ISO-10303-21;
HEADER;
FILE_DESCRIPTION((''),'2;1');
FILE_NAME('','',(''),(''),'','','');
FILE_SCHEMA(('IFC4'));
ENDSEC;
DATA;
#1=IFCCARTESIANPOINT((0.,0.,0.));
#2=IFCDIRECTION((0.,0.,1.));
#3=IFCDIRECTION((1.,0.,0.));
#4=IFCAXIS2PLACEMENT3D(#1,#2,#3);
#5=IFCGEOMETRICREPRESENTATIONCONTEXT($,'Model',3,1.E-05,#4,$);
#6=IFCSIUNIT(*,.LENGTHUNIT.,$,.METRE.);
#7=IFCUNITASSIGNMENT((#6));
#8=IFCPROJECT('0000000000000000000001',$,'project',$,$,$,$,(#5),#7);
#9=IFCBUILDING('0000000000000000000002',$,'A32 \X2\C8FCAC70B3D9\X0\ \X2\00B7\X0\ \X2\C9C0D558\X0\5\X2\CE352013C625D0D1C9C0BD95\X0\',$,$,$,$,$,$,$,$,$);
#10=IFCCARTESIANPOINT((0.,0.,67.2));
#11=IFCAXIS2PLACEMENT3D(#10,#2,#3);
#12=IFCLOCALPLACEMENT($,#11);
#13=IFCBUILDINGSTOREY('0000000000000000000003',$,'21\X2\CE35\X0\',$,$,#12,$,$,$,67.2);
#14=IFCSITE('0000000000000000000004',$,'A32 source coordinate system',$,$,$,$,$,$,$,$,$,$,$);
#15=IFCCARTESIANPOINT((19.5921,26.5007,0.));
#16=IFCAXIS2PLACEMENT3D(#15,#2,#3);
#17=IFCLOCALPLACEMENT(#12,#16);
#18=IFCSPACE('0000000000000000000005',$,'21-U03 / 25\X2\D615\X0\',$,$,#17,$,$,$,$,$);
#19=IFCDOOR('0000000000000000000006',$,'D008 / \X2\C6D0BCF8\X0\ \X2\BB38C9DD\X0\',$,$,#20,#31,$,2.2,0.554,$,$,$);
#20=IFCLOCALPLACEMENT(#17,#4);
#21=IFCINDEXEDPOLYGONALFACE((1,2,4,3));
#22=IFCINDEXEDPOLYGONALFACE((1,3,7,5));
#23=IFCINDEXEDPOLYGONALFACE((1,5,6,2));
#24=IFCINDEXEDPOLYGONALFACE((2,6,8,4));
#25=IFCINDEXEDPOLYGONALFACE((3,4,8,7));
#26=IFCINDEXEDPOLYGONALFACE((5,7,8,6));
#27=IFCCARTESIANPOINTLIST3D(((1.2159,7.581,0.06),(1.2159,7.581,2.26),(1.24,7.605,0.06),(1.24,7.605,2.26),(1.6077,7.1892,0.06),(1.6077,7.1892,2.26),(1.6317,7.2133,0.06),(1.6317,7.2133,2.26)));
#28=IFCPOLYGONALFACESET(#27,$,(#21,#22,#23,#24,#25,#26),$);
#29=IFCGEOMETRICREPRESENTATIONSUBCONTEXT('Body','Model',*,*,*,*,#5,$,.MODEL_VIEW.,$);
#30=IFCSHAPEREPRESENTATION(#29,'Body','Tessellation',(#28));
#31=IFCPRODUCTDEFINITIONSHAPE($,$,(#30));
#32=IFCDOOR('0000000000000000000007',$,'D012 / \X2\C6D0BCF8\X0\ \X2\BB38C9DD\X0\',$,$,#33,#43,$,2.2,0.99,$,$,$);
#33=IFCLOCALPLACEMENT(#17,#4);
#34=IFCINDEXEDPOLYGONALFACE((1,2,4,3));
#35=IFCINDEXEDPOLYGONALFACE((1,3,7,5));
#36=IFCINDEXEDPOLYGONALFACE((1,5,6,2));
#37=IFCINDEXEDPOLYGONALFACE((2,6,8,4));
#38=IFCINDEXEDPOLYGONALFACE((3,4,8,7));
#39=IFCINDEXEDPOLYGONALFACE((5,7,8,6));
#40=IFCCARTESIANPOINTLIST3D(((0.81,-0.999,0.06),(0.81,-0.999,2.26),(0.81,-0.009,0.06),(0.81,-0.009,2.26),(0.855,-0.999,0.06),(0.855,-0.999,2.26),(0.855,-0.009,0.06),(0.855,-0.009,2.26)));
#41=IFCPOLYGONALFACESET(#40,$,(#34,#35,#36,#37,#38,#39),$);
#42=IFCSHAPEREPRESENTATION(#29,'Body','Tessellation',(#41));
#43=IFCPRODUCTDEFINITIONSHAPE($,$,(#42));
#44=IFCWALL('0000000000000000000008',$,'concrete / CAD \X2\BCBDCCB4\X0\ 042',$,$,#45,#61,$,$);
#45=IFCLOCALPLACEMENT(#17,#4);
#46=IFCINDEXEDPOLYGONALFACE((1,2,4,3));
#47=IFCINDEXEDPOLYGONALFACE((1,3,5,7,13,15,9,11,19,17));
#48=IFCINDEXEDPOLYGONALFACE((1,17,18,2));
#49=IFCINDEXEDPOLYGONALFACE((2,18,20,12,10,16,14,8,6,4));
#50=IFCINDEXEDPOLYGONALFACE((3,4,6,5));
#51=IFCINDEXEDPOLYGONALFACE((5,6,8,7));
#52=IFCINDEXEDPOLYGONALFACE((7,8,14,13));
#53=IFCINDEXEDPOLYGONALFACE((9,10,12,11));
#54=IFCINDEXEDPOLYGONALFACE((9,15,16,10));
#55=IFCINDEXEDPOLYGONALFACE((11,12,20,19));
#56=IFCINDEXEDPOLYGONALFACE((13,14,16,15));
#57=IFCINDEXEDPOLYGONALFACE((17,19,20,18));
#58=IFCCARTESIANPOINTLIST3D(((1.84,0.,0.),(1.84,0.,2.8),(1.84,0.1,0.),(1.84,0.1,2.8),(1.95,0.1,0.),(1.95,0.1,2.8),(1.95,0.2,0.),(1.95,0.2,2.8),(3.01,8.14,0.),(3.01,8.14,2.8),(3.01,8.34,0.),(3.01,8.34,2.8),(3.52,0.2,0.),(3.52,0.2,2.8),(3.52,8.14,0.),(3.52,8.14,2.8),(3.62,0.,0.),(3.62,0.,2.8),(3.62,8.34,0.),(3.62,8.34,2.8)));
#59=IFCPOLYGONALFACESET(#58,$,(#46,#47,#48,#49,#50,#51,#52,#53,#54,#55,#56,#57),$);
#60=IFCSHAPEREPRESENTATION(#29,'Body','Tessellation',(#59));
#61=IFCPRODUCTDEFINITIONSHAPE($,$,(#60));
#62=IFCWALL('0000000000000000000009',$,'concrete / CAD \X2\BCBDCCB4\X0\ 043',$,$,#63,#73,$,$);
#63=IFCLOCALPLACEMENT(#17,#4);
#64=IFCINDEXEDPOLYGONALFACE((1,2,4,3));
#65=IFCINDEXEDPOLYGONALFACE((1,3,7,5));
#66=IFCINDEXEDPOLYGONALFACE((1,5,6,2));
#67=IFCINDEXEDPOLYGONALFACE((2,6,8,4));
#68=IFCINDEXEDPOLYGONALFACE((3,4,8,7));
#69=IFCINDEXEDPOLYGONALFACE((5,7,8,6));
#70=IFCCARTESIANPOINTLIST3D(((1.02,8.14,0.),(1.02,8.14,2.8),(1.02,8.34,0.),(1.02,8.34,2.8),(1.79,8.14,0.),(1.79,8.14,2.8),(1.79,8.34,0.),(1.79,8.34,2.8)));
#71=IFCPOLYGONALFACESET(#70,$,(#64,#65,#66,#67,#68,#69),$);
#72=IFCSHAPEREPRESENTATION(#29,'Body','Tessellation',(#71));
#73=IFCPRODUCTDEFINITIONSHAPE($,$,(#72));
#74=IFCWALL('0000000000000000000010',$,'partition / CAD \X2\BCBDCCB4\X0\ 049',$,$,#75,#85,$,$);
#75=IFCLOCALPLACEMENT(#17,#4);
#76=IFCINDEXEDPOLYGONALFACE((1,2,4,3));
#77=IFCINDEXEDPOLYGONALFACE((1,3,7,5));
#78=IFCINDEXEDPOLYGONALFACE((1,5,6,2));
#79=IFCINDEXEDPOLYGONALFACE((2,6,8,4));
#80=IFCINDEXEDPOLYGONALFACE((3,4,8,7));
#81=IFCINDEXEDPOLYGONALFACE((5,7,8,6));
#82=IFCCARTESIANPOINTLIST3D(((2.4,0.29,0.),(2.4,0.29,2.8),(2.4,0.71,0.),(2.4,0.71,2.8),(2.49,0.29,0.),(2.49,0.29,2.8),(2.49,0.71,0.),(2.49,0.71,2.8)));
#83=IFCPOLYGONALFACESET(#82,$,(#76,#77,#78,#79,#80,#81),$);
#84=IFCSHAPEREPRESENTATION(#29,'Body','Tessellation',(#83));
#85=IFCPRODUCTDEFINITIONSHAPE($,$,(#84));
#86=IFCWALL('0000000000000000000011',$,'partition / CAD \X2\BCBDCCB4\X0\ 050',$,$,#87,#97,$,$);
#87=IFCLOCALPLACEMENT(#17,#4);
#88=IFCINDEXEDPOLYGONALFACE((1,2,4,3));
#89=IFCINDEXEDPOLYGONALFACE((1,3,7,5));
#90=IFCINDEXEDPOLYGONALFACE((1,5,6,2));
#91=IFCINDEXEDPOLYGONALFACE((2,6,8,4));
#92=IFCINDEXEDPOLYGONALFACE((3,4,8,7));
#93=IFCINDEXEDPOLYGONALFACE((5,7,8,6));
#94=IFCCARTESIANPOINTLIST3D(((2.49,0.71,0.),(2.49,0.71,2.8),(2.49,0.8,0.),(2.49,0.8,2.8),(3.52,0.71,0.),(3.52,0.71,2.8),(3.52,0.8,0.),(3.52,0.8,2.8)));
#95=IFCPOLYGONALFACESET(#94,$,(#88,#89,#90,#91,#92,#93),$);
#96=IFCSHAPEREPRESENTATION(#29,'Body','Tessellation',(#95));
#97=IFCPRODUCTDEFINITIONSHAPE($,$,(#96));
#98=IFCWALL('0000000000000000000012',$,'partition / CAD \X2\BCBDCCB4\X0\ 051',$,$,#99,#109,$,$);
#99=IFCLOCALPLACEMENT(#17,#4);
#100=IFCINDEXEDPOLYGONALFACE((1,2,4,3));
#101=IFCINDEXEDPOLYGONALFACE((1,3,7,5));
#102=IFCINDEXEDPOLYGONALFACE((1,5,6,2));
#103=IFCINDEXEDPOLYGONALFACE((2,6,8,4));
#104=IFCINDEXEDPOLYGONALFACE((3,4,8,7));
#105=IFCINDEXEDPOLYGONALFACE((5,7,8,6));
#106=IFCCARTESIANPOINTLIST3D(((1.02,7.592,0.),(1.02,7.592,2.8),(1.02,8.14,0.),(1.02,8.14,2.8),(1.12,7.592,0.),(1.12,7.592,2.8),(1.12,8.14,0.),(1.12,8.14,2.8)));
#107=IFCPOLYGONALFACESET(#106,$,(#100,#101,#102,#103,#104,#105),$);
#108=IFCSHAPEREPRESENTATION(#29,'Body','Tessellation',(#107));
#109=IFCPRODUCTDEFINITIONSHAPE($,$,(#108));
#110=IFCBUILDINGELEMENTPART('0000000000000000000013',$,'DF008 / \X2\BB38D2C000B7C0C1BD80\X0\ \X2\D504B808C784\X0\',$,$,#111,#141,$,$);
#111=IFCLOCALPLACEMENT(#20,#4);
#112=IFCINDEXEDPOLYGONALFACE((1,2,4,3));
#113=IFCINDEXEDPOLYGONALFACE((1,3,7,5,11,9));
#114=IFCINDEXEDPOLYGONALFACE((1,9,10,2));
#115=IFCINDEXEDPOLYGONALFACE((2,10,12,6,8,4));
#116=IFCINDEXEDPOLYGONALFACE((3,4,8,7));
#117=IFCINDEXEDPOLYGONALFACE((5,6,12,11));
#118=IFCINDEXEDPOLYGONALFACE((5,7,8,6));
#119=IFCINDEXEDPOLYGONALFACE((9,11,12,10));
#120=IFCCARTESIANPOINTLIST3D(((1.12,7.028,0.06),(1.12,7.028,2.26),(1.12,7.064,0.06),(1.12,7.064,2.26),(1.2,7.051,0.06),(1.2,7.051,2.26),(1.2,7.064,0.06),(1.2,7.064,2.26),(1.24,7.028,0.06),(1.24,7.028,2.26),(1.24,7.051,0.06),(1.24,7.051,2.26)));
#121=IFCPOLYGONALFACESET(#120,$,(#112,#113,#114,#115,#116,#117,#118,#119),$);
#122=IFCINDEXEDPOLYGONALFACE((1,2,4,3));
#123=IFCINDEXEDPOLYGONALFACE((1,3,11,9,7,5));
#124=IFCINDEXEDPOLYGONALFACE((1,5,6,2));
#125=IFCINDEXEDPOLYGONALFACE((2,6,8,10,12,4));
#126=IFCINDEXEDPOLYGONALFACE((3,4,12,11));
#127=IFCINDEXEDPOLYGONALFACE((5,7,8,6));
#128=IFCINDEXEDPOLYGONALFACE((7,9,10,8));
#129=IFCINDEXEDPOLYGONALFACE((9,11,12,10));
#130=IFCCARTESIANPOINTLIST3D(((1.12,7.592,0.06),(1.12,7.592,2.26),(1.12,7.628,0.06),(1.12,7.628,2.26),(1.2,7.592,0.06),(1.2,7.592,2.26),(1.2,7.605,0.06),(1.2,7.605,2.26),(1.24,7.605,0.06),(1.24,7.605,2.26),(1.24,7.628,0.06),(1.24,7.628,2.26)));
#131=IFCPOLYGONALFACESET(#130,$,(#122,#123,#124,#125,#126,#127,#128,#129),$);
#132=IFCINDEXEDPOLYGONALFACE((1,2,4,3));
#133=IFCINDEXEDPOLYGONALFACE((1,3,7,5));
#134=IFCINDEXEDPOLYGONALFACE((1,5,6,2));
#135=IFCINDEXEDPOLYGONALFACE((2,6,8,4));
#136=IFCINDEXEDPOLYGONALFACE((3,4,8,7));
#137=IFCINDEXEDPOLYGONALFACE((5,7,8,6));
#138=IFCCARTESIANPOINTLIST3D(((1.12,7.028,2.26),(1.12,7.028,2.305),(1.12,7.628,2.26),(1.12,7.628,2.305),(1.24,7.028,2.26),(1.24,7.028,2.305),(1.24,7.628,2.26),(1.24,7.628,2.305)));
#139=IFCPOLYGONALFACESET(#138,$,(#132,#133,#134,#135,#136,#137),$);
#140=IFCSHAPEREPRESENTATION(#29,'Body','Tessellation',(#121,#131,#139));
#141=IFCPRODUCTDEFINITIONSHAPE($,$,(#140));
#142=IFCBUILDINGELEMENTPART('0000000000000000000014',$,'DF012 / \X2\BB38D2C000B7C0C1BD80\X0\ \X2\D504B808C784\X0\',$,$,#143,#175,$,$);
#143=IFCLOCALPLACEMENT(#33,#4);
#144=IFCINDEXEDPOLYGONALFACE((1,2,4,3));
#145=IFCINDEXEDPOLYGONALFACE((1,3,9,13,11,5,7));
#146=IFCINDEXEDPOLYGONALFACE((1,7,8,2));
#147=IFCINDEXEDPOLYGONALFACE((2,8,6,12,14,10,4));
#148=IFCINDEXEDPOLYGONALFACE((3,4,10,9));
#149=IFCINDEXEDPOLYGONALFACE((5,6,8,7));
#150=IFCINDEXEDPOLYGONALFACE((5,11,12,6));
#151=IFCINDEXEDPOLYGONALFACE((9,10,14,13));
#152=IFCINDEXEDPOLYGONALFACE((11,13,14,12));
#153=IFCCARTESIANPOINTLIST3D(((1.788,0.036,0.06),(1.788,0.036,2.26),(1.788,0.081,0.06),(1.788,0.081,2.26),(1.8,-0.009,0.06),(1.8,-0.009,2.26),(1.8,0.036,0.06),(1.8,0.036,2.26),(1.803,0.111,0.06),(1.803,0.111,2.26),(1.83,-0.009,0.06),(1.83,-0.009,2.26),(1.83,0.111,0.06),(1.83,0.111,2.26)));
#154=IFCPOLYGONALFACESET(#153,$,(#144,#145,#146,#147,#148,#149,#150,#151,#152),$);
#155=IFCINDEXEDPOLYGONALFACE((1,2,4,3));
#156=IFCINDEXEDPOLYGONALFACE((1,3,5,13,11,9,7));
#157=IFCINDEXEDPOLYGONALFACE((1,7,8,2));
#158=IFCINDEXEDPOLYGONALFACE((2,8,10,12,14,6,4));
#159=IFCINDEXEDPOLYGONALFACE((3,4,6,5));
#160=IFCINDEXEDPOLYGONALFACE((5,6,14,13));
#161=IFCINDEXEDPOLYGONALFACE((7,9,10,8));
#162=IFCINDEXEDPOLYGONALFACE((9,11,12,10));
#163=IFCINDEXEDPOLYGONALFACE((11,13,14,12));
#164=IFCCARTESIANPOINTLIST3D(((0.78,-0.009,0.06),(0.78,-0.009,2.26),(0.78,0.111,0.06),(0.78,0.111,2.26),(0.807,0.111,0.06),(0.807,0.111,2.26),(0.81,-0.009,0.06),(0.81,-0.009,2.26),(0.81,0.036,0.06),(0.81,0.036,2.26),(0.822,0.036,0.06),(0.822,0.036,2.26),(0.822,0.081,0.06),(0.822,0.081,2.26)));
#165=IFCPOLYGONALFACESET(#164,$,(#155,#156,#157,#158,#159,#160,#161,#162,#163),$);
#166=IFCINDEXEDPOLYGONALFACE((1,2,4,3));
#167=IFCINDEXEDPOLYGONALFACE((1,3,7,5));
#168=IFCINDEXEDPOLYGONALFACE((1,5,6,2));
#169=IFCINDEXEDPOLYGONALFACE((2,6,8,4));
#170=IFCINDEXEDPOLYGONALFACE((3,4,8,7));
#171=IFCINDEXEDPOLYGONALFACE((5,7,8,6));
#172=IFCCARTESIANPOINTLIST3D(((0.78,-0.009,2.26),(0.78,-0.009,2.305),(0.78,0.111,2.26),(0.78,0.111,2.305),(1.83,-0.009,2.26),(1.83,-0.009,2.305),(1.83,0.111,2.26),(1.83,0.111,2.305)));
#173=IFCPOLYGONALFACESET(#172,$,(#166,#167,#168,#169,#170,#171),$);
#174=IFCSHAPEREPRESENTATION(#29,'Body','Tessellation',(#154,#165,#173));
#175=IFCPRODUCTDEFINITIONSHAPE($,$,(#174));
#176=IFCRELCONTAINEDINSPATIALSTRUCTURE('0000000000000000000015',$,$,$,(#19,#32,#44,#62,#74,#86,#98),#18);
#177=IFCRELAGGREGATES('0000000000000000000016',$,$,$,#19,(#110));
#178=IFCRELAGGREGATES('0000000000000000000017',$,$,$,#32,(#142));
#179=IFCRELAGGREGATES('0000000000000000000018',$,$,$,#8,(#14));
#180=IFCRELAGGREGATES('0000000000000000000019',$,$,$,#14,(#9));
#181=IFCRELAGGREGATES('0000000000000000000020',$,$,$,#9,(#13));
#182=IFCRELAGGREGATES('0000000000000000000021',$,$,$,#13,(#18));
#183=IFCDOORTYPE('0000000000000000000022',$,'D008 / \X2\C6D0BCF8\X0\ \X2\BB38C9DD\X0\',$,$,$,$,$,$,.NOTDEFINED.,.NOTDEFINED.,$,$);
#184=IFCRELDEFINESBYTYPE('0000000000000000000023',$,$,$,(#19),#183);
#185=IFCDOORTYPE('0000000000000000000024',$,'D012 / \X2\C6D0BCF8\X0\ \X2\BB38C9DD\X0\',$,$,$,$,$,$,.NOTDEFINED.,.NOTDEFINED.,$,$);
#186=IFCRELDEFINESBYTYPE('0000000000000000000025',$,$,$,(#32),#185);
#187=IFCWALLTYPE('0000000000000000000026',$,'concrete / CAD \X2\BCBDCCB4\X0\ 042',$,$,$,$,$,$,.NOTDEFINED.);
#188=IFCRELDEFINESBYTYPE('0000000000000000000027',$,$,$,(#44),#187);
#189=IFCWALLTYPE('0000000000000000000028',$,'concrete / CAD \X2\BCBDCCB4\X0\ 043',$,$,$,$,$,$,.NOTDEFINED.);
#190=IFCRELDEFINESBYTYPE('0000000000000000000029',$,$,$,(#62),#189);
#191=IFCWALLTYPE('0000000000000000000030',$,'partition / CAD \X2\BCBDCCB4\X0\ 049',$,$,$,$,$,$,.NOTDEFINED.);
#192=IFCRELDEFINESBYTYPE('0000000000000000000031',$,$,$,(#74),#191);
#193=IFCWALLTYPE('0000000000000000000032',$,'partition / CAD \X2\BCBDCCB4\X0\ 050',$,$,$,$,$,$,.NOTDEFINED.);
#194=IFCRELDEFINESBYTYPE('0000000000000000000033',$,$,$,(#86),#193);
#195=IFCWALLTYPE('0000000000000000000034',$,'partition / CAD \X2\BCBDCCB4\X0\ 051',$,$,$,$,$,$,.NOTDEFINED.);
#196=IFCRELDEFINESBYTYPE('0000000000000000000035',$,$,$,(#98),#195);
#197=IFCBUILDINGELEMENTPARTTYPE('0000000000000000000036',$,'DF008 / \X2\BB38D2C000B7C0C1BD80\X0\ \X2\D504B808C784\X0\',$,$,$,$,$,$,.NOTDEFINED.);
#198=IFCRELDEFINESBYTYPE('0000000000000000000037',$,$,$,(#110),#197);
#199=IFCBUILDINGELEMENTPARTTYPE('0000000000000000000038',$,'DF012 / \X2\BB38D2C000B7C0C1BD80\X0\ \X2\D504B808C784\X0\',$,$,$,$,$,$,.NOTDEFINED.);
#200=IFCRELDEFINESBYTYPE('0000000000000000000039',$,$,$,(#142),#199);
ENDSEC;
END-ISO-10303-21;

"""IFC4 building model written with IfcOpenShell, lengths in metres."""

from ifc_helpers import new_model, si_unit, frame, origin, origin_with_axes, place, context, subcontext, project, spatial, polyline, outline, extrude, source, transform, mapped, type_object, type_shapes, element, aggregate, save


model = new_model("IFC4")

# Units and contexts
model_context = context("Model", 3, precision=1e-05, world=origin_with_axes())
body_context = subcontext(model_context, "Body", "Model", "MODEL_VIEW")
ifc_project = project(units=[si_unit("LENGTHUNIT", "METRE")], contexts=[model_context])

# Site, building, storey, space
storey_placement = place(None, frame((0.0, 0.0, 67.2), z_axis=(0.0, 0.0, 1.0), x_axis=(1.0, 0.0, 0.0)))
space_placement = place(storey_placement, frame((19.5921, 26.5007, 0.0), z_axis=(0.0, 0.0, 1.0), x_axis=(1.0, 0.0, 0.0)))
site = spatial("IfcSite", under=ifc_project, Name="A32 source coordinate system")
building = spatial("IfcBuilding", under=site, Name="A32 주거동 · 지하5층–옥탑지붕")
storey = spatial("IfcBuildingStorey", under=building, at=storey_placement, Name="21층", Elevation=67.2)
space = spatial("IfcSpace", under=storey, at=space_placement, Name="21-U03 / 25형")

# Doors
door_type_1 = type_object("IfcDoorType", Name="D008 / 원본 문짝", OperationType="NOTDEFINED", PredefinedType="NOTDEFINED")
shared_shape_1 = source(origin(), body_context, "Body", "SweptSolid", [
    extrude(outline(polyline([(1.24, 7.605), (1.6317, 7.2133), (1.6077, 7.1892), (1.2159, 7.581), (1.24, 7.605)])), frame((0.0, 0.0, 0.06)), (0.0, 0.0, 1.0), 2.2),
])
type_shapes(door_type_1, [shared_shape_1])
door_1_placement = place(space_placement, origin_with_axes())
door_1 = element("IfcDoor", 1, at=door_1_placement, inside=space, type_object=door_type_1, Name="D008 / 원본 문짝", OverallHeight=2.2, OverallWidth=0.554, context=body_context, shape_type="MappedRepresentation", body=[
    mapped(shared_shape_1, transform((0.0, 0.0, 0.0), scale=1.0)),
])
door_type_2 = type_object("IfcDoorType", Name="D012 / 원본 문짝", OperationType="NOTDEFINED", PredefinedType="NOTDEFINED")
shared_shape_2 = source(origin(), body_context, "Body", "SweptSolid", [
    extrude(outline(polyline([(0.855, -0.999), (0.81, -0.999), (0.81, -0.009), (0.855, -0.009), (0.855, -0.999)])), frame((0.0, 0.0, 0.06)), (0.0, 0.0, 1.0), 2.2),
])
type_shapes(door_type_2, [shared_shape_2])
door_2_placement = place(space_placement, origin_with_axes())
door_2 = element("IfcDoor", 2, at=door_2_placement, inside=space, type_object=door_type_2, Name="D012 / 원본 문짝", OverallHeight=2.2, OverallWidth=0.99, context=body_context, shape_type="MappedRepresentation", body=[
    mapped(shared_shape_2, transform((0.0, 0.0, 0.0), scale=1.0)),
])

# Walls
wall_type_1 = type_object("IfcWallType", Name="concrete / CAD 벽체 042", PredefinedType="NOTDEFINED")
shared_shape_3 = source(origin(), body_context, "Body", "SweptSolid", [
    extrude(outline(polyline([(3.01, 8.34), (3.97, 8.34), (3.97, 8.34), (3.62, 8.34), (3.62, 0.0), (1.84, 0.0), (1.84, 0.1), (1.95, 0.1), (1.95, 0.2), (3.52, 0.2), (3.52, 8.14), (3.01, 8.14), (3.01, 8.34)])), origin(), (0.0, 0.0, 1.0), 2.8),
])
type_shapes(wall_type_1, [shared_shape_3])
wall_1_placement = place(space_placement, origin_with_axes())
element("IfcWall", 3, at=wall_1_placement, inside=space, type_object=wall_type_1, Name="concrete / CAD 벽체 042", context=body_context, shape_type="MappedRepresentation", body=[
    mapped(shared_shape_3, transform((0.0, 0.0, 0.0), scale=1.0)),
])
wall_type_2 = type_object("IfcWallType", Name="concrete / CAD 벽체 043", PredefinedType="NOTDEFINED")
shared_shape_4 = source(origin(), body_context, "Body", "SweptSolid", [
    extrude(outline(polyline([(1.79, 8.14), (1.02, 8.14), (1.02, 8.34), (1.79, 8.34), (1.79, 8.14)])), origin(), (0.0, 0.0, 1.0), 2.8),
])
type_shapes(wall_type_2, [shared_shape_4])
wall_2_placement = place(space_placement, origin_with_axes())
element("IfcWall", 4, at=wall_2_placement, inside=space, type_object=wall_type_2, Name="concrete / CAD 벽체 043", context=body_context, shape_type="MappedRepresentation", body=[
    mapped(shared_shape_4, transform((0.0, 0.0, 0.0), scale=1.0)),
])
wall_type_3 = type_object("IfcWallType", Name="partition / CAD 벽체 049", PredefinedType="NOTDEFINED")
shared_shape_5 = source(origin(), body_context, "Body", "SweptSolid", [
    extrude(outline(polyline([(2.49, 0.29), (2.4, 0.29), (2.4, 0.71), (2.49, 0.71), (2.49, 0.29)])), origin(), (0.0, 0.0, 1.0), 2.8),
])
type_shapes(wall_type_3, [shared_shape_5])
wall_3_placement = place(space_placement, origin_with_axes())
element("IfcWall", 5, at=wall_3_placement, inside=space, type_object=wall_type_3, Name="partition / CAD 벽체 049", context=body_context, shape_type="MappedRepresentation", body=[
    mapped(shared_shape_5, transform((0.0, 0.0, 0.0), scale=1.0)),
])
wall_type_4 = type_object("IfcWallType", Name="partition / CAD 벽체 050", PredefinedType="NOTDEFINED")
shared_shape_6 = source(origin(), body_context, "Body", "SweptSolid", [
    extrude(outline(polyline([(2.49, 0.71), (2.49, 0.8), (3.52, 0.8), (3.52, 0.71), (2.49, 0.71)])), origin(), (0.0, 0.0, 1.0), 2.8),
])
type_shapes(wall_type_4, [shared_shape_6])
wall_4_placement = place(space_placement, origin_with_axes())
element("IfcWall", 6, at=wall_4_placement, inside=space, type_object=wall_type_4, Name="partition / CAD 벽체 050", context=body_context, shape_type="MappedRepresentation", body=[
    mapped(shared_shape_6, transform((0.0, 0.0, 0.0), scale=1.0)),
])
wall_type_5 = type_object("IfcWallType", Name="partition / CAD 벽체 051", PredefinedType="NOTDEFINED")
shared_shape_7 = source(origin(), body_context, "Body", "SweptSolid", [
    extrude(outline(polyline([(1.02, 8.14), (1.12, 8.14), (1.12, 7.592), (1.02, 7.592), (1.02, 8.14)])), origin(), (0.0, 0.0, 1.0), 2.8),
])
type_shapes(wall_type_5, [shared_shape_7])
wall_5_placement = place(space_placement, origin_with_axes())
element("IfcWall", 7, at=wall_5_placement, inside=space, type_object=wall_type_5, Name="partition / CAD 벽체 051", context=body_context, shape_type="MappedRepresentation", body=[
    mapped(shared_shape_7, transform((0.0, 0.0, 0.0), scale=1.0)),
])

# Building element parts
building_element_part_type_1 = type_object("IfcBuildingElementPartType", Name="DF008 / 문틀·상부 프레임", PredefinedType="NOTDEFINED")
shared_shape_8 = source(origin(), body_context, "Body", "SweptSolid", [
    extrude(outline(polyline([(1.12, 7.064), (1.2, 7.064), (1.2, 7.051), (1.24, 7.051), (1.24, 7.028), (1.12, 7.028), (1.12, 7.064)])), frame((0.0, 0.0, 0.06)), (0.0, 0.0, 1.0), 2.2),
    extrude(outline(polyline([(1.24, 7.628), (1.24, 7.605), (1.2, 7.605), (1.2, 7.592), (1.12, 7.592), (1.12, 7.628), (1.24, 7.628)])), frame((0.0, 0.0, 0.06)), (0.0, 0.0, 1.0), 2.2),
    extrude(outline(polyline([(1.12, 7.028), (1.12, 7.628), (1.24, 7.628), (1.24, 7.028), (1.12, 7.028)])), frame((0.0, 0.0, 2.26)), (0.0, 0.0, 1.0), 0.045),
])
type_shapes(building_element_part_type_1, [shared_shape_8])
building_element_part_1_placement = place(door_1_placement, origin_with_axes())
building_element_part_1 = element("IfcBuildingElementPart", 8, at=building_element_part_1_placement, type_object=building_element_part_type_1, Name="DF008 / 문틀·상부 프레임", context=body_context, shape_type="MappedRepresentation", body=[
    mapped(shared_shape_8, transform((0.0, 0.0, 0.0), scale=1.0)),
])
aggregate(door_1, [building_element_part_1])
building_element_part_type_2 = type_object("IfcBuildingElementPartType", Name="DF012 / 문틀·상부 프레임", PredefinedType="NOTDEFINED")
shared_shape_9 = source(origin(), body_context, "Body", "SweptSolid", [
    extrude(outline(polyline([(1.8, -0.009), (1.8, 0.036), (1.788, 0.036), (1.788, 0.081), (1.803, 0.111), (1.83, 0.111), (1.83, -0.009), (1.8, -0.009)])), frame((0.0, 0.0, 0.06)), (0.0, 0.0, 1.0), 2.2),
    extrude(outline(polyline([(0.78, 0.111), (0.807, 0.111), (0.822, 0.081), (0.822, 0.036), (0.81, 0.036), (0.81, -0.009), (0.78, -0.009), (0.78, 0.111)])), frame((0.0, 0.0, 0.06)), (0.0, 0.0, 1.0), 2.2),
    extrude(outline(polyline([(0.78, -0.009), (0.78, 0.111), (1.83, 0.111), (1.83, -0.009), (0.78, -0.009)])), frame((0.0, 0.0, 2.26)), (0.0, 0.0, 1.0), 0.045),
])
type_shapes(building_element_part_type_2, [shared_shape_9])
building_element_part_2_placement = place(door_2_placement, origin_with_axes())
building_element_part_2 = element("IfcBuildingElementPart", 9, at=building_element_part_2_placement, type_object=building_element_part_type_2, Name="DF012 / 문틀·상부 프레임", context=body_context, shape_type="MappedRepresentation", body=[
    mapped(shared_shape_9, transform((0.0, 0.0, 0.0), scale=1.0)),
])
aggregate(door_2, [building_element_part_2])

save(model, "model.ifc")
